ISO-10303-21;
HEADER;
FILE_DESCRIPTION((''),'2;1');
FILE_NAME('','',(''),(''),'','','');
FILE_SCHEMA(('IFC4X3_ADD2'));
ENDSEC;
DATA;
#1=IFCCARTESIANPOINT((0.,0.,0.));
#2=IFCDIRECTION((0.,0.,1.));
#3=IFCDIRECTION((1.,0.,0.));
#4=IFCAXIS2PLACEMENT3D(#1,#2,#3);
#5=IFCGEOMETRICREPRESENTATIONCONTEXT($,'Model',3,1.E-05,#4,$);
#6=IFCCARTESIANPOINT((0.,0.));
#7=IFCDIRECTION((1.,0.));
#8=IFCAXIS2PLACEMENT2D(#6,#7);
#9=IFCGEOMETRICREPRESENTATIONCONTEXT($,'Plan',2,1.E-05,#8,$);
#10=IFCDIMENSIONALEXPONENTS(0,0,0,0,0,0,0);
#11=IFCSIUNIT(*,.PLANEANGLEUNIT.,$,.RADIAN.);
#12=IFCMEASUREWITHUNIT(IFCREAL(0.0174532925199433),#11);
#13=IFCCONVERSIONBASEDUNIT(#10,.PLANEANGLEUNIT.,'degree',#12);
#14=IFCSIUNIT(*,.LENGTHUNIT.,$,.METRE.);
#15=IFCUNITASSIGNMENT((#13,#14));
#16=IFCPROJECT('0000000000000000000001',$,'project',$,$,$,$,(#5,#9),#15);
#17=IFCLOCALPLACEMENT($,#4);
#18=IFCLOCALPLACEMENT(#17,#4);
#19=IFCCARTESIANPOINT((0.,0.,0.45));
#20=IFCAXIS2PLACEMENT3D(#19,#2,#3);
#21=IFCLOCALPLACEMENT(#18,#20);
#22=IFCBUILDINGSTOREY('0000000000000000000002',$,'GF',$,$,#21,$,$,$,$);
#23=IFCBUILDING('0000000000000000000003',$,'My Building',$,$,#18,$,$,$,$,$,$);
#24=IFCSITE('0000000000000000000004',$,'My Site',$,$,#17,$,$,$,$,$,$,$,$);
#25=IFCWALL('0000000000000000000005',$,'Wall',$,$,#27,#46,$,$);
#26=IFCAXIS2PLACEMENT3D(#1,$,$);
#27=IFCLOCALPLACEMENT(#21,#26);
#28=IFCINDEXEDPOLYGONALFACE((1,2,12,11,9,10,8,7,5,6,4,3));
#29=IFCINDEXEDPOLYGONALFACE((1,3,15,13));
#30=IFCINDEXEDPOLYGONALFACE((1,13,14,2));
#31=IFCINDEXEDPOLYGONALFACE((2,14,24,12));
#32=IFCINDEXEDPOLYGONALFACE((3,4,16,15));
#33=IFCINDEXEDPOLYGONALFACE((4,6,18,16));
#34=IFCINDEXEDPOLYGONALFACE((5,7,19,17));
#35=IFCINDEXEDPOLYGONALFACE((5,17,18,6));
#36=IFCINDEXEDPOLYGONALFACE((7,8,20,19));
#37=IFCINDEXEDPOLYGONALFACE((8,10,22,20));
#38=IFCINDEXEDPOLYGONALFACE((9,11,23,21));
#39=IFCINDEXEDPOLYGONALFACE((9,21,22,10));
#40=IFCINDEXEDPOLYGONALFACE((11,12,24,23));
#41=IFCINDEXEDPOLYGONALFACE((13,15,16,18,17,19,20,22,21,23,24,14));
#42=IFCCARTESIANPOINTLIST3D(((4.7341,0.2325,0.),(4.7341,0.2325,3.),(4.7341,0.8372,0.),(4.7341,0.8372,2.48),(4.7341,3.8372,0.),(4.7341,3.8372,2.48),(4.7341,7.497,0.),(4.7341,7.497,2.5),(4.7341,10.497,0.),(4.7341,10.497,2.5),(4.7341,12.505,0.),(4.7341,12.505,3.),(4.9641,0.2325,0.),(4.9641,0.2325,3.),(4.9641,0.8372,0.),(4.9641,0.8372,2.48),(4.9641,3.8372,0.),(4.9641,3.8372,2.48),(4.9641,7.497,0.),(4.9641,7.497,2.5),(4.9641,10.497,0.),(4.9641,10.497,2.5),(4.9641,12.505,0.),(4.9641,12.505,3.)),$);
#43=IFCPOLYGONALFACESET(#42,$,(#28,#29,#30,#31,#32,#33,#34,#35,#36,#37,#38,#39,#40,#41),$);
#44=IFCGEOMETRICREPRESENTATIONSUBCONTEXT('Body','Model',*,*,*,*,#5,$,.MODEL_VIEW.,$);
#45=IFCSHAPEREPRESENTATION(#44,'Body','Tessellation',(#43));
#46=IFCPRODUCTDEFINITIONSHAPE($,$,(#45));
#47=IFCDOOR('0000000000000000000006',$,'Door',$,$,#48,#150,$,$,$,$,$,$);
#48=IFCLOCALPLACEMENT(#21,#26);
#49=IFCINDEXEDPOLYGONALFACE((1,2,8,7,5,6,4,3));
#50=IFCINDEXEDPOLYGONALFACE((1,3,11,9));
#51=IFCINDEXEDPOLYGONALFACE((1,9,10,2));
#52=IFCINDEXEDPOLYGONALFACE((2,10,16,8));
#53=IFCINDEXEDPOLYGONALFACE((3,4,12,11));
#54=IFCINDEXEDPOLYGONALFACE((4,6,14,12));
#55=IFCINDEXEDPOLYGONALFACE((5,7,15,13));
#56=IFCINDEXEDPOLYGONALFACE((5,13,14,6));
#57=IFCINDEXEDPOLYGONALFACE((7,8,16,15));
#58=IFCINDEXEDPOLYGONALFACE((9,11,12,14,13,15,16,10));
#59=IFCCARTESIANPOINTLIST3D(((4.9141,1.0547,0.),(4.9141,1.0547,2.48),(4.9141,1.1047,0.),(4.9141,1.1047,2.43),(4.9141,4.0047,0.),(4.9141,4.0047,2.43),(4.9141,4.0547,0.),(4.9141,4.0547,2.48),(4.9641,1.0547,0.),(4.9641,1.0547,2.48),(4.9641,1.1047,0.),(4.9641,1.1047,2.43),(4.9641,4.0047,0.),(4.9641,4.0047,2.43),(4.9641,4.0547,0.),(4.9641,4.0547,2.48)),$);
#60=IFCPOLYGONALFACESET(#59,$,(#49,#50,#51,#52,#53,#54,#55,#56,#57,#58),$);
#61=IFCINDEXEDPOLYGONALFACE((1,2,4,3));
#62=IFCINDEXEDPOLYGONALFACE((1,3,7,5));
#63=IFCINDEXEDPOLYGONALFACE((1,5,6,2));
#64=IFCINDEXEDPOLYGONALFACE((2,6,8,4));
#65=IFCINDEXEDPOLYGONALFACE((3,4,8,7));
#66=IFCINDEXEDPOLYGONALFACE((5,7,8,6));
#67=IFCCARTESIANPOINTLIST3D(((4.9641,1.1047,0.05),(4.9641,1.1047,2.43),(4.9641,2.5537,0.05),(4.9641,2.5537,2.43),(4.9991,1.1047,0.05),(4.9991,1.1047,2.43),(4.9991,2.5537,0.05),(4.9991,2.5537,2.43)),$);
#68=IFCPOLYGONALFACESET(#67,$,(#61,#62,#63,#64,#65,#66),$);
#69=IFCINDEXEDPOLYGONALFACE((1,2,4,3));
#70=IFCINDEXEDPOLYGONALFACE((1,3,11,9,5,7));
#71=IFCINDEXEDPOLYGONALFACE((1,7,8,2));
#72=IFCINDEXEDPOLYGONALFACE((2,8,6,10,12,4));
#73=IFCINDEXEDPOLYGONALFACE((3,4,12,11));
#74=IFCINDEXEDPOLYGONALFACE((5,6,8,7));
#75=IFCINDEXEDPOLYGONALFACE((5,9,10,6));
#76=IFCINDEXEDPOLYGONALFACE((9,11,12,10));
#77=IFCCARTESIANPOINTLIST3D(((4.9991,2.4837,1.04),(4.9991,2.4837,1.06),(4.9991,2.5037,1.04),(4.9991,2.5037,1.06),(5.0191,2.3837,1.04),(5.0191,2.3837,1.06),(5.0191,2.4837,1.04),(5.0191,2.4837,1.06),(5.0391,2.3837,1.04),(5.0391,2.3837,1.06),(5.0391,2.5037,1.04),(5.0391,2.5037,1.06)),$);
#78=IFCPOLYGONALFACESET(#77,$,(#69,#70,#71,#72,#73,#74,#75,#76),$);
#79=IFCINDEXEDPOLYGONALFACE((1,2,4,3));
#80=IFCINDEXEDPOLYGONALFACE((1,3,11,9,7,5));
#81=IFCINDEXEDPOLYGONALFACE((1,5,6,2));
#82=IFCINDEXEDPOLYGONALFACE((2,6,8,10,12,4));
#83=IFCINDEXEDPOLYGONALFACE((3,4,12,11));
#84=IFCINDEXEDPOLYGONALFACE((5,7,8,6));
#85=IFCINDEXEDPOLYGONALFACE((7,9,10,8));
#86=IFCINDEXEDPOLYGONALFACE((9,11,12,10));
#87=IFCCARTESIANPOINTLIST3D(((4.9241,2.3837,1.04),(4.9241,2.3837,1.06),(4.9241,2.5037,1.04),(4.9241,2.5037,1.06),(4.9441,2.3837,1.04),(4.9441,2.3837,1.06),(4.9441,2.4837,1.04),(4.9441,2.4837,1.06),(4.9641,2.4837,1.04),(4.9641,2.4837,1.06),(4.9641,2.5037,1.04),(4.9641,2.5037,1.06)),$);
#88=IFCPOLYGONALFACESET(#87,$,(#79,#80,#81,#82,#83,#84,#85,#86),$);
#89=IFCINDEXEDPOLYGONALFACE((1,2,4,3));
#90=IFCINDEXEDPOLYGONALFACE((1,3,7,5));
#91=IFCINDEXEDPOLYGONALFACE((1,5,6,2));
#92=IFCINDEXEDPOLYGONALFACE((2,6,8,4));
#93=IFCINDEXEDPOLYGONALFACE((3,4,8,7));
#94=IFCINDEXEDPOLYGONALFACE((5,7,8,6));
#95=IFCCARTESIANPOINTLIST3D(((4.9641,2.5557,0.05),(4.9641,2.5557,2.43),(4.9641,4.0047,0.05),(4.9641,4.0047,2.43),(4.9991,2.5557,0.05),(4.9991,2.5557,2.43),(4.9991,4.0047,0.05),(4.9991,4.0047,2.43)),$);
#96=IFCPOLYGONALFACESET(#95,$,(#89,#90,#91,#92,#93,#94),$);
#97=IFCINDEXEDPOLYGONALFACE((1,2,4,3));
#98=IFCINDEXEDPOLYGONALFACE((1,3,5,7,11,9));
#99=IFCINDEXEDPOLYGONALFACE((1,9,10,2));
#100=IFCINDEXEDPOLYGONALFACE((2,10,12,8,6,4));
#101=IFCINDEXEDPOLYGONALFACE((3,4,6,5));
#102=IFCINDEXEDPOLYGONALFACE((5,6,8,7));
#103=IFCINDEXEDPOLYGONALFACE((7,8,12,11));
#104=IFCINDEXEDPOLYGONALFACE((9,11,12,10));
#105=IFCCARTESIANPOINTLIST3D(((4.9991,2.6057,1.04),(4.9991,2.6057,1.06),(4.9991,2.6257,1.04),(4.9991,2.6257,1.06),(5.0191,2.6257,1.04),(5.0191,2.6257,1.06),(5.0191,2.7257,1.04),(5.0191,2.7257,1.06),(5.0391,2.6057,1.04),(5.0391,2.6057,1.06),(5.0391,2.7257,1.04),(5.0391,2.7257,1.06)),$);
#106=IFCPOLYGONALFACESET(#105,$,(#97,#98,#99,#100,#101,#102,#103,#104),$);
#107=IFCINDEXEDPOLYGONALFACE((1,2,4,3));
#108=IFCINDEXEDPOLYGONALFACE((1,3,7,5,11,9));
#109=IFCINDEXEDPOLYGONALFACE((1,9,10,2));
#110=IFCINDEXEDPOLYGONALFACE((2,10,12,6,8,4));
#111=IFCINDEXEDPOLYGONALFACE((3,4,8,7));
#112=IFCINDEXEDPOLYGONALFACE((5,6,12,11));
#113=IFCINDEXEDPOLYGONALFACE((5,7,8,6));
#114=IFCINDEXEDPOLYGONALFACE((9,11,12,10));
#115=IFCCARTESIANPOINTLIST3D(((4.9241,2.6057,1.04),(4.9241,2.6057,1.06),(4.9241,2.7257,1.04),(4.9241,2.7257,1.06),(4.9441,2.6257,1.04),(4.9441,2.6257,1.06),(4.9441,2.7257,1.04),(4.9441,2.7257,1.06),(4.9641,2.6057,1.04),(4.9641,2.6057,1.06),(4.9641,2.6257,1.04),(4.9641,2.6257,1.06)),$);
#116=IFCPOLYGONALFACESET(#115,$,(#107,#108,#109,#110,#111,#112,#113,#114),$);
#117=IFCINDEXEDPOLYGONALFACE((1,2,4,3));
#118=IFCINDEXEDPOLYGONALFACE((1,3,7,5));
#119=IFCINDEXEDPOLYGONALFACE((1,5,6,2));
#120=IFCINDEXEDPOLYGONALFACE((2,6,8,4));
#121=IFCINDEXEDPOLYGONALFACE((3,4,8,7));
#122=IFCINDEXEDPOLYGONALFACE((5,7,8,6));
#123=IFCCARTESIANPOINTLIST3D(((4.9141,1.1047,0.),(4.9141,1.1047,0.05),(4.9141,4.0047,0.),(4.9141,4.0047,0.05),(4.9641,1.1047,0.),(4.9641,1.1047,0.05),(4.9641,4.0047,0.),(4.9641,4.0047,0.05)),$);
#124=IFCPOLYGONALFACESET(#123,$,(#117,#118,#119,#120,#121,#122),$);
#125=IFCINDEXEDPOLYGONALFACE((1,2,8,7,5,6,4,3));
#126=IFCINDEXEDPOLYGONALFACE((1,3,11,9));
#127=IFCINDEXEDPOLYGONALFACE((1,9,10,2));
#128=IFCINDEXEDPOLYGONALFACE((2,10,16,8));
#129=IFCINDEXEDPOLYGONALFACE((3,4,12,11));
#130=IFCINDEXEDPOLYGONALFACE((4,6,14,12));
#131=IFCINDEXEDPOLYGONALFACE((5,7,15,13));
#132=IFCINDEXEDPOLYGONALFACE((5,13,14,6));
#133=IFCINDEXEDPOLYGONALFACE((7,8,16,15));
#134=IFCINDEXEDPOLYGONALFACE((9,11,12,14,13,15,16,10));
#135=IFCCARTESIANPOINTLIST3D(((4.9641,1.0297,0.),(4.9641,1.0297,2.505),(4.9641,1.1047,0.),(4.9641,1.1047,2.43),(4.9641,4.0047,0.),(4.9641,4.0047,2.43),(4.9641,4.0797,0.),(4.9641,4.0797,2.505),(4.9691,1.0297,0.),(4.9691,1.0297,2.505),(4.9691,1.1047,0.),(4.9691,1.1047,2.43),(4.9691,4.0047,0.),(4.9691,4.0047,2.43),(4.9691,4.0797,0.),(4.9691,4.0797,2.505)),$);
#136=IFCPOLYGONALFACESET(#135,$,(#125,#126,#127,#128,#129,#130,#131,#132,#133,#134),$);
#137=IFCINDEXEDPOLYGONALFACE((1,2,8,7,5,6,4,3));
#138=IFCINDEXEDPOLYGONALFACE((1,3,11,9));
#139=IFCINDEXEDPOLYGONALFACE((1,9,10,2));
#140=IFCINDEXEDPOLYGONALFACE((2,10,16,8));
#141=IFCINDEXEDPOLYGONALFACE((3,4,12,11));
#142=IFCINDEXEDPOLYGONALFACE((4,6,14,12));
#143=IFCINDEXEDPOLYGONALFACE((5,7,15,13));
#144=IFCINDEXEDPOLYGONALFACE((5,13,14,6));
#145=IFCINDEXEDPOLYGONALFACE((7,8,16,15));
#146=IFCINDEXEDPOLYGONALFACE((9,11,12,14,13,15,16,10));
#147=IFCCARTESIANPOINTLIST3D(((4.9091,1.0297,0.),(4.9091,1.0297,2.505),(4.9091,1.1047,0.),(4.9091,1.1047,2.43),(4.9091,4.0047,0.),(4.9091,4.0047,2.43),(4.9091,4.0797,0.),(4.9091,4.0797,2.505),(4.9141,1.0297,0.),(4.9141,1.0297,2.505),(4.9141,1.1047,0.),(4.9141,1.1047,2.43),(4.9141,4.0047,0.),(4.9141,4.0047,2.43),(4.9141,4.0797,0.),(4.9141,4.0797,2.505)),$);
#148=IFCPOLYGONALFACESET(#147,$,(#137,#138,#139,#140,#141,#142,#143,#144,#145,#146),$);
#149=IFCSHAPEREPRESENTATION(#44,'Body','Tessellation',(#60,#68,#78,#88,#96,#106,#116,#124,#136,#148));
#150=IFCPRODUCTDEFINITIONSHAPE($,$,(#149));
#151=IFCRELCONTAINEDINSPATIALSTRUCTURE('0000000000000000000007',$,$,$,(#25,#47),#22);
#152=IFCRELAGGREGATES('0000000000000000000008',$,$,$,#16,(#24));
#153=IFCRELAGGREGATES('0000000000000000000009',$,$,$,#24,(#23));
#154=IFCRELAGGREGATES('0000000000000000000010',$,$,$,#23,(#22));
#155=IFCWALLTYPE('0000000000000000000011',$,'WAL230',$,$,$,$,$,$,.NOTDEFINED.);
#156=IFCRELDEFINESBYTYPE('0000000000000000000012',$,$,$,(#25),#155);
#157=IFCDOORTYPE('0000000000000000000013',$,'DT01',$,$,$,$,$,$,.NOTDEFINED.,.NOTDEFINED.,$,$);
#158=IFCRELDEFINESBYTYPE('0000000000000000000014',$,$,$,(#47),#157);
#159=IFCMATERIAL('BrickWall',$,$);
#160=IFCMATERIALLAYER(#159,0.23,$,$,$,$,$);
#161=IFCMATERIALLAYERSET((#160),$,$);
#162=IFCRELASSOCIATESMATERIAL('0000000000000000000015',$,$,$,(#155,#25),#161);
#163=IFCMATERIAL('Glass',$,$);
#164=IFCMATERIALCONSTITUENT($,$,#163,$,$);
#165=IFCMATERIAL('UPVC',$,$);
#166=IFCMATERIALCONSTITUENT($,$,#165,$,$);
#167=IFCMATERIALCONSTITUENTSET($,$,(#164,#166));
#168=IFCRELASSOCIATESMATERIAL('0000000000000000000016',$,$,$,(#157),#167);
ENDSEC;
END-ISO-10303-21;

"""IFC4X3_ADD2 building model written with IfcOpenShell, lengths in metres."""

from ifc_helpers import new_model, entity, si_unit, converted_unit, frame, origin_with_axes, origin_2d_with_axis, place, context, subcontext, project, spatial, line, indexed_curve, outline, extrude, shape, source, transform, mapped, material, layer, layer_set, layer_usage, constituent, constituent_set, type_object, type_shapes, element, fill, save


model = new_model("IFC4X3_ADD2")

# Units and contexts
model_context = context("Model", 3, precision=1e-05, world=origin_with_axes())
plan_context = context("Plan", 2, precision=1e-05, world=origin_2d_with_axis())
body_context_1 = subcontext(model_context, "Body", "Model", "MODEL_VIEW")
body_context_2 = subcontext(plan_context, "Body", "Plan", "PLAN_VIEW")
ifc_project = project(units=[converted_unit("PLANEANGLEUNIT", "degree", entity("IfcReal", 0.0174532925199433), si_unit("PLANEANGLEUNIT", "RADIAN"), dimensions=[0, 0, 0, 0, 0, 0, 0]), si_unit("LENGTHUNIT", "METRE")], contexts=[model_context, plan_context])

# Site, building, storey
site_placement = place(None, origin_with_axes())
site = spatial("IfcSite", under=ifc_project, at=site_placement, Name="My Site")
building_placement = place(site_placement, origin_with_axes())
building = spatial("IfcBuilding", under=site, at=building_placement, Name="My Building")
storey_placement = place(building_placement, frame((0.0, 0.0, 0.45), z_axis=(0.0, 0.0, 1.0), x_axis=(1.0, 0.0, 0.0)))
storey = spatial("IfcBuildingStorey", under=building, at=storey_placement, Name="GF")

# Shared definitions
ifc_material_1 = material(Name="BrickWall")

# Wall, openings, door
ifc_layer_1 = layer(ifc_material_1, 0.23)
ifc_layer_set_1 = layer_set([ifc_layer_1])
ifc_layer_usage_1 = layer_usage(ifc_layer_set_1, "AXIS2", "POSITIVE", 0.0)
wall_type_1 = type_object("IfcWallType", Name="WAL230", PredefinedType="NOTDEFINED", material=ifc_layer_set_1)
wall_1_placement = place(storey_placement, frame((4.9641, 0.2325, 0.0), z_axis=(0.0, 0.0, 1.0), x_axis=(0.0, 1.0, 0.0)))
wall_1 = element("IfcWall", 1, at=wall_1_placement, inside=storey, type_object=wall_type_1, material=ifc_layer_usage_1, Name="Wall", context=body_context_1, shape_type="SweptSolid", body=[
    extrude(outline(indexed_curve([(0.0, 0.0), (0.0, 0.23), (12.2725, 0.23), (12.2725, 0.0), (0.0, 0.0)], self_intersect=False)), origin_with_axes(), (0.0, 0.0, 1.0), 3.0),
])
shared_shape_1 = source(origin_with_axes(), body_context_1, "Body", "SweptSolid", [
    extrude(outline(indexed_curve([(0.0, 0.0), (3.0, 0.0), (3.0, 2.5), (0.0, 2.5)], segments=[line(1, 2, 3, 4, 1)])), frame((0.0, -0.6, 0.0), z_axis=(0.0, -1.0, 0.0), x_axis=(1.0, 0.0, 0.0)), (0.0, 0.0, -1.0), 1.2),
])
opening_1_placement = place(wall_1_placement, frame((7.2645, 0.0189, 0.0), z_axis=(0.0, 0.0, 1.0), x_axis=(1.0, 0.0, 0.0)))
element("IfcOpeningElement", 2, at=opening_1_placement, cuts=wall_1, PredefinedType="OPENING", context=body_context_1, shape_type="MappedRepresentation", body=[
    mapped(shared_shape_1, transform((0.0, 0.0, 0.0), x_axis=(1.0, 0.0, 0.0), y_axis=(0.0, 1.0, 0.0), z_axis=(0.0, 0.0, 1.0), scale=1.0)),
])
shared_shape_2 = source(origin_with_axes(), body_context_1, "Body", "SweptSolid", [
    extrude(outline(indexed_curve([(0.0, 0.0), (3.0, 0.0), (3.0, 2.48), (0.0, 2.48)], segments=[line(1, 2, 3, 4, 1)])), frame((0.0, -0.6, 0.0), z_axis=(0.0, -1.0, 0.0), x_axis=(1.0, 0.0, 0.0)), (0.0, 0.0, -1.0), 1.2),
])
opening_2_placement = place(wall_1_placement, frame((0.6047, 0.0189, 0.0), z_axis=(0.0, 0.0, 1.0), x_axis=(1.0, 0.0, 0.0)))
opening_2 = element("IfcOpeningElement", 3, at=opening_2_placement, cuts=wall_1, PredefinedType="OPENING", context=body_context_1, shape_type="MappedRepresentation", body=[
    mapped(shared_shape_2, transform((0.0, 0.0, 0.0), x_axis=(1.0, 0.0, 0.0), y_axis=(0.0, 1.0, 0.0), z_axis=(0.0, 0.0, 1.0), scale=1.0)),
])
ifc_material_2 = material(Name="Glass")
ifc_constituent_1 = constituent(ifc_material_2)
ifc_material_3 = material(Name="UPVC")
ifc_constituent_2 = constituent(ifc_material_3)
ifc_constituent_set = constituent_set(constituents=[ifc_constituent_1, ifc_constituent_2])
door_type_1 = type_object("IfcDoorType", Name="DT01", OperationType="NOTDEFINED", PredefinedType="NOTDEFINED", material=ifc_constituent_set)
shared_shape_3 = source(origin_with_axes(), body_context_1, "Body", "SweptSolid", [
    extrude(outline(indexed_curve([(3.0, 0.0), (3.0, 2.48), (0.0, 2.48), (0.0, 0.0), (0.05, 0.0), (0.05, 2.43), (2.95, 2.43), (2.95, 0.0)], segments=[line(5, 4), line(4, 3), line(3, 2), line(2, 1), line(1, 8), line(8, 7), line(7, 6), line(6, 5)], self_intersect=False)), frame((0.0, 0.0, 0.0), z_axis=(0.0, -1.0, 0.0), x_axis=(1.0, 0.0, 0.0)), (0.0, 0.0, -1.0), 0.05),
    extrude(outline(indexed_curve([(0.0, 0.0), (1.449, 0.0), (1.449, 0.035), (0.0, 0.035)], segments=[line(1, 2, 3, 4, 1)])), frame((0.05, -0.035, 0.05), z_axis=(0.0, 0.0, 1.0), x_axis=(1.0, 0.0, 0.0)), (0.0, 0.0, 1.0), 2.38),
    extrude(outline(indexed_curve([(0.0, 0.0), (0.0, -0.04), (-0.12, -0.04), (-0.12, -0.02), (-0.02, -0.02), (-0.02, 0.0)], segments=[line(1, 2, 3, 4, 5, 6, 1)])), frame((1.449, -0.035, 1.04), z_axis=(0.0, 0.0, 1.0), x_axis=(1.0, 0.0, 0.0)), (0.0, 0.0, 1.0), 0.02),
    extrude(outline(indexed_curve([(0.0, 0.0), (0.0, 0.04), (-0.12, 0.04), (-0.12, 0.02), (-0.02, 0.02), (-0.02, 0.0)], segments=[line(1, 2, 3, 4, 5, 6, 1)])), frame((1.449, 0.0, 1.04), z_axis=(0.0, 0.0, 1.0), x_axis=(1.0, 0.0, 0.0)), (0.0, 0.0, 1.0), 0.02),
    extrude(outline(indexed_curve([(0.0, 0.0), (-1.449, 0.0), (-1.449, 0.035), (0.0, 0.035)], segments=[line(1, 2, 3, 4, 1)])), frame((2.95, -0.035, 0.05), z_axis=(0.0, 0.0, 1.0), x_axis=(1.0, 0.0, 0.0)), (0.0, 0.0, 1.0), 2.38),
    extrude(outline(indexed_curve([(0.0, 0.0), (0.0, -0.04), (0.12, -0.04), (0.12, -0.02), (0.02, -0.02), (0.02, 0.0)], segments=[line(1, 2, 3, 4, 5, 6, 1)])), frame((1.551, -0.035, 1.04), z_axis=(0.0, 0.0, 1.0), x_axis=(1.0, 0.0, 0.0)), (0.0, 0.0, 1.0), 0.02),
    extrude(outline(indexed_curve([(0.0, 0.0), (0.0, 0.04), (0.12, 0.04), (0.12, 0.02), (0.02, 0.02), (0.02, 0.0)], segments=[line(1, 2, 3, 4, 5, 6, 1)])), frame((1.551, 0.0, 1.04), z_axis=(0.0, 0.0, 1.0), x_axis=(1.0, 0.0, 0.0)), (0.0, 0.0, 1.0), 0.02),
    extrude(outline(indexed_curve([(0.0, 0.0), (2.9, 0.0), (2.9, 0.05), (0.0, 0.05)], segments=[line(1, 2, 3, 4, 1)])), frame((0.05, 0.0, 0.0), z_axis=(0.0, 0.0, 1.0), x_axis=(1.0, 0.0, 0.0)), (0.0, 0.0, 1.0), 0.05),
    extrude(outline(indexed_curve([(0.0, 0.0), (0.0, 2.505), (3.05, 2.505), (3.05, 0.0), (2.975, 0.0), (2.975, 2.43), (0.075, 2.43), (0.075, 0.0)], segments=[line(1, 2, 3, 4, 5, 6, 7, 8, 1)])), frame((-0.025, -0.005, 0.0), z_axis=(0.0, -1.0, 0.0), x_axis=(1.0, 0.0, 0.0)), (0.0, 0.0, -1.0), 0.005),
    extrude(outline(indexed_curve([(0.0, 0.0), (0.0, 2.505), (3.05, 2.505), (3.05, 0.0), (2.975, 0.0), (2.975, 2.43), (0.075, 2.43), (0.075, 0.0)], segments=[line(1, 2, 3, 4, 5, 6, 7, 8, 1)])), frame((-0.025, 0.05, 0.0), z_axis=(0.0, -1.0, 0.0), x_axis=(1.0, 0.0, 0.0)), (0.0, 0.0, -1.0), 0.005),
])
shared_shape_4 = source(origin_with_axes(), body_context_2, "Body", "Curve2D", [
    entity("IfcIndexedPolyCurve", entity("IfcCartesianPointList2D", [[0.0, 0.0], [0.05, 0.0], [0.05, 0.05], [0.0, 0.05]]), [entity("IfcLineIndex", [1, 2, 3, 4, 1])]),
    entity("IfcIndexedPolyCurve", entity("IfcCartesianPointList2D", [[3.0, 0.0], [2.95, 0.0], [2.95, 0.05], [3.0, 0.05]]), [entity("IfcLineIndex", [1, 2, 3, 4, 1])]),
    entity("IfcIndexedPolyCurve", entity("IfcCartesianPointList2D", [[-0.675, -0.035], [0.775, -0.035], [0.775, 0.0], [-0.675, 0.0]]), [entity("IfcLineIndex", [1, 2, 3, 4, 1])]),
    entity("IfcIndexedPolyCurve", entity("IfcCartesianPointList2D", [[3.675, -0.035], [2.225, -0.035], [2.225, 0.0], [3.675, 0.0]]), [entity("IfcLineIndex", [1, 2, 3, 4, 1])]),
])
type_shapes(door_type_1, [shared_shape_3, shared_shape_4])
door_1_placement = place(opening_2_placement, frame((0.2175, -0.0189, 0.0), z_axis=(0.0, 0.0, 1.0), x_axis=(1.0, 0.0, 0.0)))
door_1 = element("IfcDoor", 4, at=door_1_placement, inside=storey, type_object=door_type_1, Name="Door", shapes=[
    shape(body_context_1, "Body", "MappedRepresentation", [mapped(shared_shape_3, transform((0.0, 0.0, 0.0), x_axis=(1.0, 0.0, 0.0), y_axis=(0.0, 1.0, 0.0), z_axis=(0.0, 0.0, 1.0), scale=1.0))]),
    shape(body_context_2, "Body", "MappedRepresentation", [mapped(shared_shape_4, transform((0.0, 0.0, 0.0), x_axis=(1.0, 0.0, 0.0), y_axis=(0.0, 1.0, 0.0), z_axis=(0.0, 0.0, 1.0), scale=1.0))]),
])
fill(opening_2, door_1)

save(model, "model.ifc")
